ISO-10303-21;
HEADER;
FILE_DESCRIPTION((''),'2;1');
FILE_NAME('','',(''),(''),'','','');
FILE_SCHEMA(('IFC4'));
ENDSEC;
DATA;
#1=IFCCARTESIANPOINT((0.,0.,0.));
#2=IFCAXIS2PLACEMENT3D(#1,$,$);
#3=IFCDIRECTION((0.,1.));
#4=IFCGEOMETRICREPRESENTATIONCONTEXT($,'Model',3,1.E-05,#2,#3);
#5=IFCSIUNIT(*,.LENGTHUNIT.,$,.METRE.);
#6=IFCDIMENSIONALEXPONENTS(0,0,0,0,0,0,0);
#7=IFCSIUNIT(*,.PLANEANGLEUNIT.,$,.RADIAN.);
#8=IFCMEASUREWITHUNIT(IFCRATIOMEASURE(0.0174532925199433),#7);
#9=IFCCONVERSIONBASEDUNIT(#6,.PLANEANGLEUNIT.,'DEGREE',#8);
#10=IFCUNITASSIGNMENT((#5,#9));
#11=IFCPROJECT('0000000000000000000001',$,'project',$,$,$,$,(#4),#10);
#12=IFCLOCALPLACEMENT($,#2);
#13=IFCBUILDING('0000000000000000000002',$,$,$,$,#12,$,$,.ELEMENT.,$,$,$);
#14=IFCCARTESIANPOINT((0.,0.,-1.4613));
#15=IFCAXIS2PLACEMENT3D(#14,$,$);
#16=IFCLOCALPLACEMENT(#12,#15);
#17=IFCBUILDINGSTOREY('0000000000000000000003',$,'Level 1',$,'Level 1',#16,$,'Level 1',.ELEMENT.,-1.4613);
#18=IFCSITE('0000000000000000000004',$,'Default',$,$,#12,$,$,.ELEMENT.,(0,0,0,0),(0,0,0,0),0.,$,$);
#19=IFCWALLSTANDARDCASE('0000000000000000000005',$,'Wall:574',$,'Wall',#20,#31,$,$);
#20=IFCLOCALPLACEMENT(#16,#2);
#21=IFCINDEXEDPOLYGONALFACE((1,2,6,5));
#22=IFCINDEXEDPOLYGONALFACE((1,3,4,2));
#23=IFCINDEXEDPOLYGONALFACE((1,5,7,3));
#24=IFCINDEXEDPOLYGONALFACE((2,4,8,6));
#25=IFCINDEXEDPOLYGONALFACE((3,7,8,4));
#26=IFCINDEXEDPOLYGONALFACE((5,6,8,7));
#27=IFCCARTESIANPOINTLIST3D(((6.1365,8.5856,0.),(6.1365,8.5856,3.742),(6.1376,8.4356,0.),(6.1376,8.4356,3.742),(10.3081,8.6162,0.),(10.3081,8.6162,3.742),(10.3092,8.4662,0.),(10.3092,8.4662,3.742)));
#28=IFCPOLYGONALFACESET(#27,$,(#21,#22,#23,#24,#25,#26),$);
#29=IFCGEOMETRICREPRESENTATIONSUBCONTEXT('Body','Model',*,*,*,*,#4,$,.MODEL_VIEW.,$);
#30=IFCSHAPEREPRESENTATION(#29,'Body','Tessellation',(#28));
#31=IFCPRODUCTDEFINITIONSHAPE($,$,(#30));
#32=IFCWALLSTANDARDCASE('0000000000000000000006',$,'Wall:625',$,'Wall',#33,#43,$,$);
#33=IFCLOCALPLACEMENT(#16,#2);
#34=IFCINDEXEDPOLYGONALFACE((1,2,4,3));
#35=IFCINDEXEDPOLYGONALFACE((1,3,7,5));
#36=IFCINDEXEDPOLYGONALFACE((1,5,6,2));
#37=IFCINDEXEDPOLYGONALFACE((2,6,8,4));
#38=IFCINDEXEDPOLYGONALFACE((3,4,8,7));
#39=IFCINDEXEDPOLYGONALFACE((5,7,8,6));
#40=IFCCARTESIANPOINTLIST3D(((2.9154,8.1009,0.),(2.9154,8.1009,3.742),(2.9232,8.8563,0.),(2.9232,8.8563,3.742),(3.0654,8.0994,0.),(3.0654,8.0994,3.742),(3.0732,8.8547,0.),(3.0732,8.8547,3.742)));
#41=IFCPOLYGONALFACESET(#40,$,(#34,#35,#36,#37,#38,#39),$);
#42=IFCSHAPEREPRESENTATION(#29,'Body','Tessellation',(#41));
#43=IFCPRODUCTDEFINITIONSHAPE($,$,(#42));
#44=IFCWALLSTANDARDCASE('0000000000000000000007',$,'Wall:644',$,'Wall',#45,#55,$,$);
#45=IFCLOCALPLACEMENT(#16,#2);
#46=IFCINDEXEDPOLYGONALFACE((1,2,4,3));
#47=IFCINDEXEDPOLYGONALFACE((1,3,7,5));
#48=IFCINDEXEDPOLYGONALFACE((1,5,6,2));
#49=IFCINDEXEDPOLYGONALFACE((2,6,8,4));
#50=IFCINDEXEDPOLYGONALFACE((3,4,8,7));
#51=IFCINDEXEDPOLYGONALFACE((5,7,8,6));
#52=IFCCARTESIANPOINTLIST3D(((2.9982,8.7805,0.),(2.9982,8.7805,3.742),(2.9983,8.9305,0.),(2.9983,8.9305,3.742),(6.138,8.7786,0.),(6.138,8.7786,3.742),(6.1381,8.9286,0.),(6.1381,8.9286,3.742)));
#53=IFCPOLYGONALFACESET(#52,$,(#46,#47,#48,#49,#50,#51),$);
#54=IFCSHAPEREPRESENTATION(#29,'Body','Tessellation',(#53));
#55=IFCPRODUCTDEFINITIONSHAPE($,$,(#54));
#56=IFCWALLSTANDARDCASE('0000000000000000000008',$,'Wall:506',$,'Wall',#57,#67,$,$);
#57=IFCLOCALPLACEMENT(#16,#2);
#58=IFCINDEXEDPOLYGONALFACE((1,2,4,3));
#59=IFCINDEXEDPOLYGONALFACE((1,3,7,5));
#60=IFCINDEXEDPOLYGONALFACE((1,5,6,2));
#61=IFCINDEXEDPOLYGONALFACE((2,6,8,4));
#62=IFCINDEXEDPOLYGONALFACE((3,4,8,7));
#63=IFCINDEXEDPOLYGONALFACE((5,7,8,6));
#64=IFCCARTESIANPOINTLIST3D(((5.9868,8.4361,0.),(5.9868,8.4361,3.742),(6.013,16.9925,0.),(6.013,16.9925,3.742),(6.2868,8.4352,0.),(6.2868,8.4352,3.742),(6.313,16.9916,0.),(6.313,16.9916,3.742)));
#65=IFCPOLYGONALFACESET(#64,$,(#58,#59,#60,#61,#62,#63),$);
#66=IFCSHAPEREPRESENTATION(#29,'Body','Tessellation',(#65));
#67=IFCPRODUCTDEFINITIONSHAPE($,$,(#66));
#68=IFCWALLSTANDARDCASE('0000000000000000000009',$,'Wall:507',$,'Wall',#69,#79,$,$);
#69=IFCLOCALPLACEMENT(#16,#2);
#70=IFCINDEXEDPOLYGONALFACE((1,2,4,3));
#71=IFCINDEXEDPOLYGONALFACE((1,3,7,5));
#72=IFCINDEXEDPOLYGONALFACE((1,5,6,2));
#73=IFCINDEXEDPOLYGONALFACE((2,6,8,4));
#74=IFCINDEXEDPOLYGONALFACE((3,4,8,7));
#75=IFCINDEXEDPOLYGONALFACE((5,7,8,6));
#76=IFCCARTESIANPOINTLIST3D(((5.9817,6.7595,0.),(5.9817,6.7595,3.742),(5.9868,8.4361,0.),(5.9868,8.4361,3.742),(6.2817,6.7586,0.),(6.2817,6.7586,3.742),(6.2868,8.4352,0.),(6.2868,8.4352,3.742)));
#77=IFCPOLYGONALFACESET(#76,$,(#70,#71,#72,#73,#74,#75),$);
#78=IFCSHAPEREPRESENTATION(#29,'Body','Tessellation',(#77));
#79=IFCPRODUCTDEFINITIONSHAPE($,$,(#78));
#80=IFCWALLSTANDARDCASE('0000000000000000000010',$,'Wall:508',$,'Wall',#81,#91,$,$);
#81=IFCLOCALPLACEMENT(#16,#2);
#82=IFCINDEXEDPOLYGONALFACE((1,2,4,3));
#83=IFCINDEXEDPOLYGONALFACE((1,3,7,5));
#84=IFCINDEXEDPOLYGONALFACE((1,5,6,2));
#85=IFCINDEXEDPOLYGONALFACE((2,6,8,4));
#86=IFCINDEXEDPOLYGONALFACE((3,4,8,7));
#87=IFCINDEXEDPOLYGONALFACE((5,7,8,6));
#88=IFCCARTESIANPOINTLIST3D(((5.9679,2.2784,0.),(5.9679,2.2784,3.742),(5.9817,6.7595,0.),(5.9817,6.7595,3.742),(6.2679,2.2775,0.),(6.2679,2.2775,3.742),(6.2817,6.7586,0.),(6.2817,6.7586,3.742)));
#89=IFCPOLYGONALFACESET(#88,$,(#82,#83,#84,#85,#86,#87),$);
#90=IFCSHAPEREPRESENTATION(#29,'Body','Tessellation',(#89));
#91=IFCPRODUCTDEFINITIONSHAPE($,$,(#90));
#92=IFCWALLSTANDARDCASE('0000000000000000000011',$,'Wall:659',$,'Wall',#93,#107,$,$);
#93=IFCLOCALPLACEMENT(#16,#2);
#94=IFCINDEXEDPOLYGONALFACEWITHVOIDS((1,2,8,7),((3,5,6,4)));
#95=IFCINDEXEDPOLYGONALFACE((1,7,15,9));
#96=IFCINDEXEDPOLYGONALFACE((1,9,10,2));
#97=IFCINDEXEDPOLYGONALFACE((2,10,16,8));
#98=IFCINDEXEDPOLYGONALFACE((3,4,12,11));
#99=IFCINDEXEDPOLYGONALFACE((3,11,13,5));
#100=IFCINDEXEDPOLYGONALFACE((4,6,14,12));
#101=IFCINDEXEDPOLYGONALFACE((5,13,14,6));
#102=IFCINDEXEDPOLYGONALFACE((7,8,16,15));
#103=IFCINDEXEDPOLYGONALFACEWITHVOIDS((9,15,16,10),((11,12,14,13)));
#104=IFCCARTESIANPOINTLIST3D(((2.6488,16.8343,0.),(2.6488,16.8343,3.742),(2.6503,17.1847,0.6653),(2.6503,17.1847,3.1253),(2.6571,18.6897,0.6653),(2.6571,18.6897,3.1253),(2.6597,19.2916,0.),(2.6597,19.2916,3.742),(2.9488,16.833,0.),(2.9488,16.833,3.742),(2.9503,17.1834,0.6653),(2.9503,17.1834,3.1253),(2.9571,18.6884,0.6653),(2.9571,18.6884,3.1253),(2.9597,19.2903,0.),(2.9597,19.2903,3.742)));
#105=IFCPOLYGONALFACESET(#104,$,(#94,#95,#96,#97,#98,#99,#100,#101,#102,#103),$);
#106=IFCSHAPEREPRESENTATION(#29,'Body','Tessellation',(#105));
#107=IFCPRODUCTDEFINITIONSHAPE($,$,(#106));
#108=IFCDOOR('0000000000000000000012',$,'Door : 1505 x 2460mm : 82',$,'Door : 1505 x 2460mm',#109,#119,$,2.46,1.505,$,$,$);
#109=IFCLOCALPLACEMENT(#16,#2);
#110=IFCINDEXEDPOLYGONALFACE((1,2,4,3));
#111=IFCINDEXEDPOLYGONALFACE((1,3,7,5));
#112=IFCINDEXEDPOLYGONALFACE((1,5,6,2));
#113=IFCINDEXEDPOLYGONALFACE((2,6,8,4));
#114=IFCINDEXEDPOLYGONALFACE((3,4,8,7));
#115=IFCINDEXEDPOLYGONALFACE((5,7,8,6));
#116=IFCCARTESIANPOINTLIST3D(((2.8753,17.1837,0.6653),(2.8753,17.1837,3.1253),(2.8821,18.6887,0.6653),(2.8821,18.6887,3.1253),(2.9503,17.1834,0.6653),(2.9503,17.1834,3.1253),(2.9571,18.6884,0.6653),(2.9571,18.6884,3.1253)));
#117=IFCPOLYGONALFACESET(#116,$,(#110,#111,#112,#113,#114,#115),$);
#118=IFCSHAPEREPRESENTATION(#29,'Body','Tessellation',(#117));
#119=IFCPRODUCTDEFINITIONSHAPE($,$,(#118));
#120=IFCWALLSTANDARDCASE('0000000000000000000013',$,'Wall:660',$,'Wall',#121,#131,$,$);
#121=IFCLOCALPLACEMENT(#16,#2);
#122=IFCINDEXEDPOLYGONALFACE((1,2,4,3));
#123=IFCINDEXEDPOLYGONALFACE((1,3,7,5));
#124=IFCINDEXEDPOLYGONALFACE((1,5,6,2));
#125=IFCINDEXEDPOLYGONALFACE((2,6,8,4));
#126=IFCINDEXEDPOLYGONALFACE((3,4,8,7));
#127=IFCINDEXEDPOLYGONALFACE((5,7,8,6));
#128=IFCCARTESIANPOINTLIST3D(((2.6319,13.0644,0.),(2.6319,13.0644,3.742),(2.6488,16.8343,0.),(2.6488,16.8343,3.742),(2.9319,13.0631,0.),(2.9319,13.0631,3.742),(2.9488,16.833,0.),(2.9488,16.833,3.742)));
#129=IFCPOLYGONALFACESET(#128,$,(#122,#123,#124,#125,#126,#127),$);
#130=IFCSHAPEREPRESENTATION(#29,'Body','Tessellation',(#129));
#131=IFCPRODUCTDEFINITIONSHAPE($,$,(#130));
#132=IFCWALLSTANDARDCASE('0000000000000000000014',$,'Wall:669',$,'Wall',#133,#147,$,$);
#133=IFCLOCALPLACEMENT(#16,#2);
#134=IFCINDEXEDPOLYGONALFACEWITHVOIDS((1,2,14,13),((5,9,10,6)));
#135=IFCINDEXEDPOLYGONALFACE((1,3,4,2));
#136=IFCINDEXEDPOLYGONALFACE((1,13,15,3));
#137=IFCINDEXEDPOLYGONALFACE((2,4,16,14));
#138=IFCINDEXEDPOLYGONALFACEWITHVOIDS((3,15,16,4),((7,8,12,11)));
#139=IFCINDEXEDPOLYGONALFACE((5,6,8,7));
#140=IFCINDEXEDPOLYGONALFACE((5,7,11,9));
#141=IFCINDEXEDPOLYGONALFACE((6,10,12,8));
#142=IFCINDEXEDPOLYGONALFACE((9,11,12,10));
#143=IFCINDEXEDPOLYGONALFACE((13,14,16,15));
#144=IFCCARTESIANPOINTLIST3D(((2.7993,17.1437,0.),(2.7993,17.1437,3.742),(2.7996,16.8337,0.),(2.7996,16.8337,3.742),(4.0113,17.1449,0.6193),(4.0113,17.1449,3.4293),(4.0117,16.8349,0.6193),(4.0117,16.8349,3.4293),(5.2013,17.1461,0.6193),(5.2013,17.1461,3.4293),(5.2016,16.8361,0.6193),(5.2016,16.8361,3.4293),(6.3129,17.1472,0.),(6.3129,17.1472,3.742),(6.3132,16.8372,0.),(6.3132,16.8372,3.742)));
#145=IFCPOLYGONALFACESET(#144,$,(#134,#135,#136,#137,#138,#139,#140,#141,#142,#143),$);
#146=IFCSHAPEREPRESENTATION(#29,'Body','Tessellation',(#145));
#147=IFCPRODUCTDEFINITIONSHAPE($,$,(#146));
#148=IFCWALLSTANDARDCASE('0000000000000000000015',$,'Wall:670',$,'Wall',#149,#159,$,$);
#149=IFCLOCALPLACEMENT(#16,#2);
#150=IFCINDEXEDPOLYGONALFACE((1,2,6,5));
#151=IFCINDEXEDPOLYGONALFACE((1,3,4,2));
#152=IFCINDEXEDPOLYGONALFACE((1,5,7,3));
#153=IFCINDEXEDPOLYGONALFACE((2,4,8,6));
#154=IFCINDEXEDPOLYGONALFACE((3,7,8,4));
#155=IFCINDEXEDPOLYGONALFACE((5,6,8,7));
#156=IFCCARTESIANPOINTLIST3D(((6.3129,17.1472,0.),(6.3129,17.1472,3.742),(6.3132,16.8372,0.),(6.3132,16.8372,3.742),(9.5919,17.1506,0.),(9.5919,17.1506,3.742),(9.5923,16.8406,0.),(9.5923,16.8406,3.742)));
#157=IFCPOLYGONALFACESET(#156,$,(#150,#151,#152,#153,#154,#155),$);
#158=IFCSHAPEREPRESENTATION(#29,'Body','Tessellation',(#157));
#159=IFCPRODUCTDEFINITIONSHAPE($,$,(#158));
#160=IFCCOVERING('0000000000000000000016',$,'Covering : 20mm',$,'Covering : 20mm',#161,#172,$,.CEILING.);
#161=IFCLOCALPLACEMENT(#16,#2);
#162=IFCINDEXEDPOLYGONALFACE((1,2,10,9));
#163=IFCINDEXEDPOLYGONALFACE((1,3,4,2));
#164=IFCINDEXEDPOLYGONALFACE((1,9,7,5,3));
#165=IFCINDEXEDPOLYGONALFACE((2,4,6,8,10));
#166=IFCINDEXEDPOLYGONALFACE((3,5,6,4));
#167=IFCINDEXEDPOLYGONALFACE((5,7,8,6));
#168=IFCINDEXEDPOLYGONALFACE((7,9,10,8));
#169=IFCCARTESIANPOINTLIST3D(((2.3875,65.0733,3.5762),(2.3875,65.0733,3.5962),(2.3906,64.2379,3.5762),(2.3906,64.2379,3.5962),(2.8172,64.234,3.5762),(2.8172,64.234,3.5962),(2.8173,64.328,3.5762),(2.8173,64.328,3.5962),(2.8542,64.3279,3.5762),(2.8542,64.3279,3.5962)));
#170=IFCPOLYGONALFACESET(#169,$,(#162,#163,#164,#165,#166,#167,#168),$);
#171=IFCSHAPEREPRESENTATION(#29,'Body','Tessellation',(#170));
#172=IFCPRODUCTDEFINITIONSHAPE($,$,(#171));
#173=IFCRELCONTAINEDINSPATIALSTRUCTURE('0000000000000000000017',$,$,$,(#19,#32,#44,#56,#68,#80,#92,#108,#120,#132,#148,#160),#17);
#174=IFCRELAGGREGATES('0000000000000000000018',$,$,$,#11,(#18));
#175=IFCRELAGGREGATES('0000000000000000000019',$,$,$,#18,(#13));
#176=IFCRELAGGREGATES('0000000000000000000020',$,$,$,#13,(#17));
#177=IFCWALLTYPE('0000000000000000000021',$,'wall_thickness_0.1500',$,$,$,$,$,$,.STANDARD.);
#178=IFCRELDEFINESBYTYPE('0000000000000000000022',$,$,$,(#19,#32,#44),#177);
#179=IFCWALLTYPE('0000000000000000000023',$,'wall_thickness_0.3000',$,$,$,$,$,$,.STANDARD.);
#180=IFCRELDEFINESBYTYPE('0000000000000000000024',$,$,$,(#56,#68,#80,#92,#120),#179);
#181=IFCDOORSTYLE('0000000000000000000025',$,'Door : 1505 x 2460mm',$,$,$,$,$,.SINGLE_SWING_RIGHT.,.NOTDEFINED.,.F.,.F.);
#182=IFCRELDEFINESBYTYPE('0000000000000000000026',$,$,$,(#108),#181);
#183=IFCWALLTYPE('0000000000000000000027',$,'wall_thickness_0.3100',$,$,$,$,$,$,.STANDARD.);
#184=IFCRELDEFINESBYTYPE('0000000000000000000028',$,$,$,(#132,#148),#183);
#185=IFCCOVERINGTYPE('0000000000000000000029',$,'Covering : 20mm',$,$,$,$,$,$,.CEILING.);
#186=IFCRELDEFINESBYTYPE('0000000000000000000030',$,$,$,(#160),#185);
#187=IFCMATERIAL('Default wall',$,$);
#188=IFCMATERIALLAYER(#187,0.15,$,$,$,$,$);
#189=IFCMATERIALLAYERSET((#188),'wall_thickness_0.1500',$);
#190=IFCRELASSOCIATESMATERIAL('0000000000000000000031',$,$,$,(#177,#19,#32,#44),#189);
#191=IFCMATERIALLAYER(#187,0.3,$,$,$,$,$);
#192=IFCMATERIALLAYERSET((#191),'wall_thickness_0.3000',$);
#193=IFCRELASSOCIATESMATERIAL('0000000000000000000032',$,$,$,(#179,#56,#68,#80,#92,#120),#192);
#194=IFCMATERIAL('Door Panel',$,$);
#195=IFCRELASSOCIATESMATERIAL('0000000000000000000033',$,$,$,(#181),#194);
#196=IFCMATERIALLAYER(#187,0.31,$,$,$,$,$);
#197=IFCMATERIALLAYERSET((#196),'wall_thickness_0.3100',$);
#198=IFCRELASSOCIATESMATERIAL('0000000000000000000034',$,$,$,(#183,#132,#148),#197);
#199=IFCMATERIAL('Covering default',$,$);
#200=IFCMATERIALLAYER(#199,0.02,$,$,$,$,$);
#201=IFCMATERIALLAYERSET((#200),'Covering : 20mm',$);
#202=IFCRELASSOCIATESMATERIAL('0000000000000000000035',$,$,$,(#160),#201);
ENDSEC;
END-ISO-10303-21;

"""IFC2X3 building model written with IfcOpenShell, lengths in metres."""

from ifc_helpers import new_model, entity, si_unit, converted_unit, direction, frame, frame_2d, origin, origin_with_axes, origin_2d_with_axis, place, context, subcontext, project, spatial, polyline, rectangle, outline, extrude, source, transform, mapped, material, layer, layer_set, layer_usage, type_object, type_shapes, element, fill, save


model = new_model("IFC2X3")

# Units and contexts
model_context = context("Model", 3, precision=1e-05, world=origin(), true_north=direction((0.0, 1.0)))
body_context = subcontext(model_context, "Body", "Model", "MODEL_VIEW")
ifc_project = project(units=[si_unit("LENGTHUNIT", "METRE"), converted_unit("PLANEANGLEUNIT", "DEGREE", entity("IfcRatioMeasure", 0.0174532925199433), si_unit("PLANEANGLEUNIT", "RADIAN"), dimensions=[0, 0, 0, 0, 0, 0, 0])], contexts=[model_context])

# Site, building, storey
placement_1 = place(None, origin())
site = spatial("IfcSite", under=ifc_project, at=placement_1, Name="Default", CompositionType="ELEMENT", RefLatitude=(0, 0, 0, 0), RefLongitude=(0, 0, 0, 0), RefElevation=0.0)
building = spatial("IfcBuilding", under=site, at=placement_1, CompositionType="ELEMENT")
storey_placement = place(placement_1, frame((0.0, 0.0, -1.4613)))
storey = spatial("IfcBuildingStorey", under=building, at=storey_placement, Name="Level 1", ObjectType="Level 1", LongName="Level 1", CompositionType="ELEMENT", Elevation=-1.4613)

# Shared definitions
ifc_material_1 = material(Name="Default wall")

# Shared definitions
ifc_material_2 = material(Name="Door Panel")

# Walls
ifc_layer_1 = layer(ifc_material_1, 0.15)
ifc_layer_set_1 = layer_set([ifc_layer_1], Name="wall_thickness_0.1500")
ifc_layer_usage_1 = layer_usage(ifc_layer_set_1, "AXIS2", "POSITIVE", -0.075)
wall_type_1 = type_object("IfcWallType", Name="wall_thickness_0.1500", PredefinedType="STANDARD", material=ifc_layer_set_1)
wall_1_placement = place(storey_placement, frame((6.137, 8.5106, 0.0), z_axis=(0.0, 0.0, 1.0), x_axis=(0.999973, 0.007315, 0.0)))
element("IfcWallStandardCase", 1, at=wall_1_placement, inside=storey, type_object=wall_type_1, material=ifc_layer_usage_1, Name="Wall:574", ObjectType="Wall", context=body_context, shape_type="SweptSolid", body=[
    extrude(outline(polyline([(4.1717, -0.075), (4.1717, 0.075), (0.0, 0.075), (0.0, -0.075), (4.1717, -0.075)])), origin(), (0.0, 0.0, 1.0), 3.742),
])
wall_2_placement = place(storey_placement, frame((2.9982, 8.8555, 0.0), z_axis=(0.0, 0.0, 1.0), x_axis=(-0.010355, -0.999946, 0.0)))
element("IfcWallStandardCase", 2, at=wall_2_placement, inside=storey, type_object=wall_type_1, material=ifc_layer_usage_1, Name="Wall:625", ObjectType="Wall", context=body_context, shape_type="SweptSolid", body=[
    extrude(outline(polyline([(0.7554, -0.075), (0.7554, 0.075), (0.0, 0.075), (0.0, -0.075), (0.7554, -0.075)])), origin(), (0.0, 0.0, 1.0), 3.742),
])
wall_3_placement = place(storey_placement, frame((2.9982, 8.8555, 0.0), z_axis=(0.0, 0.0, 1.0), x_axis=(1.0, -0.000624, 0.0)))
element("IfcWallStandardCase", 3, at=wall_3_placement, inside=storey, type_object=wall_type_1, material=ifc_layer_usage_1, Name="Wall:644", ObjectType="Wall", context=body_context, shape_type="SweptSolid", body=[
    extrude(outline(polyline([(3.1399, -0.075), (3.1399, 0.075), (0.0, 0.075), (0.0, -0.075), (3.1399, -0.075)])), origin(), (0.0, 0.0, 1.0), 3.742),
])
ifc_layer_2 = layer(ifc_material_1, 0.3)
ifc_layer_set_2 = layer_set([ifc_layer_2], Name="wall_thickness_0.3000")
ifc_layer_usage_2 = layer_usage(ifc_layer_set_2, "AXIS2", "POSITIVE", -0.15)
wall_type_2 = type_object("IfcWallType", Name="wall_thickness_0.3000", PredefinedType="STANDARD", material=ifc_layer_set_2)
wall_4_placement = place(storey_placement, frame((6.163, 16.9921, 0.0), z_axis=(0.0, 0.0, 1.0), x_axis=(-0.003064, -0.999995, 0.0)))
element("IfcWallStandardCase", 4, at=wall_4_placement, inside=storey, type_object=wall_type_2, material=ifc_layer_usage_2, Name="Wall:506", ObjectType="Wall", context=body_context, shape_type="SweptSolid", body=[
    extrude(outline(polyline([(8.5565, -0.15), (8.5565, 0.15), (0.0, 0.15), (0.0, -0.15), (8.5565, -0.15)])), origin(), (0.0, 0.0, 1.0), 3.742),
])
wall_5_placement = place(storey_placement, frame((6.1368, 8.4357, 0.0), z_axis=(0.0, 0.0, 1.0), x_axis=(-0.003064, -0.999995, 0.0)))
element("IfcWallStandardCase", 5, at=wall_5_placement, inside=storey, type_object=wall_type_2, material=ifc_layer_usage_2, Name="Wall:507", ObjectType="Wall", context=body_context, shape_type="SweptSolid", body=[
    extrude(outline(polyline([(1.6766, -0.15), (1.6766, 0.15), (0.0, 0.15), (0.0, -0.15), (1.6766, -0.15)])), origin(), (0.0, 0.0, 1.0), 3.742),
])
wall_6_placement = place(storey_placement, frame((6.1317, 6.759, 0.0), z_axis=(0.0, 0.0, 1.0), x_axis=(-0.003064, -0.999995, 0.0)))
element("IfcWallStandardCase", 6, at=wall_6_placement, inside=storey, type_object=wall_type_2, material=ifc_layer_usage_2, Name="Wall:508", ObjectType="Wall", context=body_context, shape_type="SweptSolid", body=[
    extrude(outline(polyline([(4.4812, -0.15), (4.4812, 0.15), (0.0, 0.15), (0.0, -0.15), (4.4812, -0.15)])), origin(), (0.0, 0.0, 1.0), 3.742),
])

# Wall, opening, door
wall_7_placement = place(storey_placement, frame((2.8097, 19.291, 0.0), z_axis=(0.0, 0.0, 1.0), x_axis=(-0.004466, -0.99999, 0.0)))
wall_7 = element("IfcWallStandardCase", 7, at=wall_7_placement, inside=storey, type_object=wall_type_2, material=ifc_layer_usage_2, Name="Wall:659", ObjectType="Wall", context=body_context, shape_type="SweptSolid", body=[
    extrude(outline(polyline([(2.4573, -0.15), (2.4573, 0.15), (0.0, 0.15), (0.0, -0.15), (2.4573, -0.15)])), origin(), (0.0, 0.0, 1.0), 3.742),
])
opening_1_placement = place(wall_7_placement, frame((0.6019, -0.15, 0.6653)))
opening_1 = element("IfcOpeningElement", 8, at=opening_1_placement, cuts=wall_7, ObjectType="Opening", context=body_context, shape_type="SweptSolid", body=[
    extrude(rectangle(XDim=1.505, YDim=2.46, at=frame_2d((1.23, 0.7525), x_axis=(0.0, 1.0))), frame((0.0, 0.0, 0.0), z_axis=(0.0, 1.0, 0.0), x_axis=(0.0, 0.0, 1.0)), (0.0, 0.0, 1.0), 0.3),
])
door_style_1 = type_object("IfcDoorStyle", Name="Door : 1505 x 2460mm", ConstructionType="NOTDEFINED", OperationType="SINGLE_SWING_RIGHT", ParameterTakesPrecedence=False, Sizeable=False, material=ifc_material_2)
shared_shape_1 = source(origin(), body_context, "Body", "SweptSolid", [
    extrude(rectangle(XDim=0.075, YDim=1.505, at=origin_2d_with_axis()), frame((0.7525, 0.2625, 0.0), z_axis=(0.0, 0.0, 1.0), x_axis=(0.0, 1.0, 0.0)), (0.0, 0.0, 1.0), 2.46),
])
type_shapes(door_style_1, [shared_shape_1])
door_1_placement = place(opening_1_placement, origin())
door_1 = element("IfcDoor", 9, at=door_1_placement, inside=storey, type_object=door_style_1, Name="Door : 1505 x 2460mm : 82", ObjectType="Door : 1505 x 2460mm", OverallHeight=2.46, OverallWidth=1.505, context=body_context, shape_type="MappedRepresentation", body=[
    mapped(shared_shape_1, transform((0.0, 0.0, 0.0), scale=1.0)),
])
fill(opening_1, door_1)

# Wall
wall_8_placement = place(storey_placement, frame((2.7988, 16.8337, 0.0), z_axis=(0.0, 0.0, 1.0), x_axis=(-0.004466, -0.99999, 0.0)))
element("IfcWallStandardCase", 10, at=wall_8_placement, inside=storey, type_object=wall_type_2, material=ifc_layer_usage_2, Name="Wall:660", ObjectType="Wall", context=body_context, shape_type="SweptSolid", body=[
    extrude(outline(polyline([(3.77, -0.15), (3.77, 0.15), (0.0, 0.15), (0.0, -0.15), (3.77, -0.15)])), origin(), (0.0, 0.0, 1.0), 3.742),
])

# Wall, opening
ifc_layer_3 = layer(ifc_material_1, 0.31)
ifc_layer_set_3 = layer_set([ifc_layer_3], Name="wall_thickness_0.3100")
ifc_layer_usage_3 = layer_usage(ifc_layer_set_3, "AXIS2", "POSITIVE", -0.155)
wall_type_3 = type_object("IfcWallType", Name="wall_thickness_0.3100", PredefinedType="STANDARD", material=ifc_layer_set_3)
wall_9_placement = place(storey_placement, frame((2.7995, 16.9887, 0.0), z_axis=(0.0, 0.0, 1.0), x_axis=(0.999999, 0.001018, 0.0)))
wall_9 = element("IfcWallStandardCase", 11, at=wall_9_placement, inside=storey, type_object=wall_type_3, material=ifc_layer_usage_3, Name="Wall:669", ObjectType="Wall", context=body_context, shape_type="SweptSolid", body=[
    extrude(outline(polyline([(3.5136, -0.155), (3.5136, 0.155), (0.0, 0.155), (0.0, -0.155), (3.5136, -0.155)])), origin(), (0.0, 0.0, 1.0), 3.742),
])
opening_2_placement = place(wall_9_placement, frame((1.212, -0.155, 0.6193)))
element("IfcOpeningElement", 12, at=opening_2_placement, cuts=wall_9, ObjectType="Opening", context=body_context, shape_type="SweptSolid", body=[
    extrude(rectangle(XDim=1.19, YDim=2.81, at=frame_2d((1.405, 0.595), x_axis=(0.0, 1.0))), frame((0.0, 0.0, 0.0), z_axis=(0.0, 1.0, 0.0), x_axis=(0.0, 0.0, 1.0)), (0.0, 0.0, 1.0), 0.31),
])

# Wall
wall_10_placement = place(storey_placement, frame((6.313, 16.9922, 0.0), z_axis=(0.0, 0.0, 1.0), x_axis=(0.999999, 0.001018, 0.0)))
element("IfcWallStandardCase", 13, at=wall_10_placement, inside=storey, type_object=wall_type_3, material=ifc_layer_usage_3, Name="Wall:670", ObjectType="Wall", context=body_context, shape_type="SweptSolid", body=[
    extrude(outline(polyline([(3.2791, -0.155), (3.2791, 0.155), (0.0, 0.155), (0.0, -0.155), (3.2791, -0.155)])), origin(), (0.0, 0.0, 1.0), 3.742),
])

# Covering
ifc_material_3 = material(Name="Covering default")
ifc_layer_4 = layer(ifc_material_3, 0.02)
ifc_layer_set_4 = layer_set([ifc_layer_4], Name="Covering : 20mm")
ifc_layer_usage_4 = layer_usage(ifc_layer_set_4, "AXIS3", "POSITIVE", 0.0)
covering_type_1 = type_object("IfcCoveringType", Name="Covering : 20mm", PredefinedType="CEILING")
covering_1_placement = place(placement_1, frame((0.0, 0.0, 2.1149)))
element("IfcCovering", 14, at=covering_1_placement, inside=storey, type_object=covering_type_1, material=ifc_layer_usage_4, Name="Covering : 20mm", ObjectType="Covering : 20mm", PredefinedType="CEILING", context=body_context, shape_type="SweptSolid", body=[
    extrude(outline(polyline([(2.3875, 65.0733), (2.8542, 64.3279), (2.8173, 64.328), (2.8172, 64.234), (2.3906, 64.2379), (2.3875, 65.0733)])), origin_with_axes(), (0.0, 0.0, 1.0), 0.02),
])

save(model, "model.ifc")
